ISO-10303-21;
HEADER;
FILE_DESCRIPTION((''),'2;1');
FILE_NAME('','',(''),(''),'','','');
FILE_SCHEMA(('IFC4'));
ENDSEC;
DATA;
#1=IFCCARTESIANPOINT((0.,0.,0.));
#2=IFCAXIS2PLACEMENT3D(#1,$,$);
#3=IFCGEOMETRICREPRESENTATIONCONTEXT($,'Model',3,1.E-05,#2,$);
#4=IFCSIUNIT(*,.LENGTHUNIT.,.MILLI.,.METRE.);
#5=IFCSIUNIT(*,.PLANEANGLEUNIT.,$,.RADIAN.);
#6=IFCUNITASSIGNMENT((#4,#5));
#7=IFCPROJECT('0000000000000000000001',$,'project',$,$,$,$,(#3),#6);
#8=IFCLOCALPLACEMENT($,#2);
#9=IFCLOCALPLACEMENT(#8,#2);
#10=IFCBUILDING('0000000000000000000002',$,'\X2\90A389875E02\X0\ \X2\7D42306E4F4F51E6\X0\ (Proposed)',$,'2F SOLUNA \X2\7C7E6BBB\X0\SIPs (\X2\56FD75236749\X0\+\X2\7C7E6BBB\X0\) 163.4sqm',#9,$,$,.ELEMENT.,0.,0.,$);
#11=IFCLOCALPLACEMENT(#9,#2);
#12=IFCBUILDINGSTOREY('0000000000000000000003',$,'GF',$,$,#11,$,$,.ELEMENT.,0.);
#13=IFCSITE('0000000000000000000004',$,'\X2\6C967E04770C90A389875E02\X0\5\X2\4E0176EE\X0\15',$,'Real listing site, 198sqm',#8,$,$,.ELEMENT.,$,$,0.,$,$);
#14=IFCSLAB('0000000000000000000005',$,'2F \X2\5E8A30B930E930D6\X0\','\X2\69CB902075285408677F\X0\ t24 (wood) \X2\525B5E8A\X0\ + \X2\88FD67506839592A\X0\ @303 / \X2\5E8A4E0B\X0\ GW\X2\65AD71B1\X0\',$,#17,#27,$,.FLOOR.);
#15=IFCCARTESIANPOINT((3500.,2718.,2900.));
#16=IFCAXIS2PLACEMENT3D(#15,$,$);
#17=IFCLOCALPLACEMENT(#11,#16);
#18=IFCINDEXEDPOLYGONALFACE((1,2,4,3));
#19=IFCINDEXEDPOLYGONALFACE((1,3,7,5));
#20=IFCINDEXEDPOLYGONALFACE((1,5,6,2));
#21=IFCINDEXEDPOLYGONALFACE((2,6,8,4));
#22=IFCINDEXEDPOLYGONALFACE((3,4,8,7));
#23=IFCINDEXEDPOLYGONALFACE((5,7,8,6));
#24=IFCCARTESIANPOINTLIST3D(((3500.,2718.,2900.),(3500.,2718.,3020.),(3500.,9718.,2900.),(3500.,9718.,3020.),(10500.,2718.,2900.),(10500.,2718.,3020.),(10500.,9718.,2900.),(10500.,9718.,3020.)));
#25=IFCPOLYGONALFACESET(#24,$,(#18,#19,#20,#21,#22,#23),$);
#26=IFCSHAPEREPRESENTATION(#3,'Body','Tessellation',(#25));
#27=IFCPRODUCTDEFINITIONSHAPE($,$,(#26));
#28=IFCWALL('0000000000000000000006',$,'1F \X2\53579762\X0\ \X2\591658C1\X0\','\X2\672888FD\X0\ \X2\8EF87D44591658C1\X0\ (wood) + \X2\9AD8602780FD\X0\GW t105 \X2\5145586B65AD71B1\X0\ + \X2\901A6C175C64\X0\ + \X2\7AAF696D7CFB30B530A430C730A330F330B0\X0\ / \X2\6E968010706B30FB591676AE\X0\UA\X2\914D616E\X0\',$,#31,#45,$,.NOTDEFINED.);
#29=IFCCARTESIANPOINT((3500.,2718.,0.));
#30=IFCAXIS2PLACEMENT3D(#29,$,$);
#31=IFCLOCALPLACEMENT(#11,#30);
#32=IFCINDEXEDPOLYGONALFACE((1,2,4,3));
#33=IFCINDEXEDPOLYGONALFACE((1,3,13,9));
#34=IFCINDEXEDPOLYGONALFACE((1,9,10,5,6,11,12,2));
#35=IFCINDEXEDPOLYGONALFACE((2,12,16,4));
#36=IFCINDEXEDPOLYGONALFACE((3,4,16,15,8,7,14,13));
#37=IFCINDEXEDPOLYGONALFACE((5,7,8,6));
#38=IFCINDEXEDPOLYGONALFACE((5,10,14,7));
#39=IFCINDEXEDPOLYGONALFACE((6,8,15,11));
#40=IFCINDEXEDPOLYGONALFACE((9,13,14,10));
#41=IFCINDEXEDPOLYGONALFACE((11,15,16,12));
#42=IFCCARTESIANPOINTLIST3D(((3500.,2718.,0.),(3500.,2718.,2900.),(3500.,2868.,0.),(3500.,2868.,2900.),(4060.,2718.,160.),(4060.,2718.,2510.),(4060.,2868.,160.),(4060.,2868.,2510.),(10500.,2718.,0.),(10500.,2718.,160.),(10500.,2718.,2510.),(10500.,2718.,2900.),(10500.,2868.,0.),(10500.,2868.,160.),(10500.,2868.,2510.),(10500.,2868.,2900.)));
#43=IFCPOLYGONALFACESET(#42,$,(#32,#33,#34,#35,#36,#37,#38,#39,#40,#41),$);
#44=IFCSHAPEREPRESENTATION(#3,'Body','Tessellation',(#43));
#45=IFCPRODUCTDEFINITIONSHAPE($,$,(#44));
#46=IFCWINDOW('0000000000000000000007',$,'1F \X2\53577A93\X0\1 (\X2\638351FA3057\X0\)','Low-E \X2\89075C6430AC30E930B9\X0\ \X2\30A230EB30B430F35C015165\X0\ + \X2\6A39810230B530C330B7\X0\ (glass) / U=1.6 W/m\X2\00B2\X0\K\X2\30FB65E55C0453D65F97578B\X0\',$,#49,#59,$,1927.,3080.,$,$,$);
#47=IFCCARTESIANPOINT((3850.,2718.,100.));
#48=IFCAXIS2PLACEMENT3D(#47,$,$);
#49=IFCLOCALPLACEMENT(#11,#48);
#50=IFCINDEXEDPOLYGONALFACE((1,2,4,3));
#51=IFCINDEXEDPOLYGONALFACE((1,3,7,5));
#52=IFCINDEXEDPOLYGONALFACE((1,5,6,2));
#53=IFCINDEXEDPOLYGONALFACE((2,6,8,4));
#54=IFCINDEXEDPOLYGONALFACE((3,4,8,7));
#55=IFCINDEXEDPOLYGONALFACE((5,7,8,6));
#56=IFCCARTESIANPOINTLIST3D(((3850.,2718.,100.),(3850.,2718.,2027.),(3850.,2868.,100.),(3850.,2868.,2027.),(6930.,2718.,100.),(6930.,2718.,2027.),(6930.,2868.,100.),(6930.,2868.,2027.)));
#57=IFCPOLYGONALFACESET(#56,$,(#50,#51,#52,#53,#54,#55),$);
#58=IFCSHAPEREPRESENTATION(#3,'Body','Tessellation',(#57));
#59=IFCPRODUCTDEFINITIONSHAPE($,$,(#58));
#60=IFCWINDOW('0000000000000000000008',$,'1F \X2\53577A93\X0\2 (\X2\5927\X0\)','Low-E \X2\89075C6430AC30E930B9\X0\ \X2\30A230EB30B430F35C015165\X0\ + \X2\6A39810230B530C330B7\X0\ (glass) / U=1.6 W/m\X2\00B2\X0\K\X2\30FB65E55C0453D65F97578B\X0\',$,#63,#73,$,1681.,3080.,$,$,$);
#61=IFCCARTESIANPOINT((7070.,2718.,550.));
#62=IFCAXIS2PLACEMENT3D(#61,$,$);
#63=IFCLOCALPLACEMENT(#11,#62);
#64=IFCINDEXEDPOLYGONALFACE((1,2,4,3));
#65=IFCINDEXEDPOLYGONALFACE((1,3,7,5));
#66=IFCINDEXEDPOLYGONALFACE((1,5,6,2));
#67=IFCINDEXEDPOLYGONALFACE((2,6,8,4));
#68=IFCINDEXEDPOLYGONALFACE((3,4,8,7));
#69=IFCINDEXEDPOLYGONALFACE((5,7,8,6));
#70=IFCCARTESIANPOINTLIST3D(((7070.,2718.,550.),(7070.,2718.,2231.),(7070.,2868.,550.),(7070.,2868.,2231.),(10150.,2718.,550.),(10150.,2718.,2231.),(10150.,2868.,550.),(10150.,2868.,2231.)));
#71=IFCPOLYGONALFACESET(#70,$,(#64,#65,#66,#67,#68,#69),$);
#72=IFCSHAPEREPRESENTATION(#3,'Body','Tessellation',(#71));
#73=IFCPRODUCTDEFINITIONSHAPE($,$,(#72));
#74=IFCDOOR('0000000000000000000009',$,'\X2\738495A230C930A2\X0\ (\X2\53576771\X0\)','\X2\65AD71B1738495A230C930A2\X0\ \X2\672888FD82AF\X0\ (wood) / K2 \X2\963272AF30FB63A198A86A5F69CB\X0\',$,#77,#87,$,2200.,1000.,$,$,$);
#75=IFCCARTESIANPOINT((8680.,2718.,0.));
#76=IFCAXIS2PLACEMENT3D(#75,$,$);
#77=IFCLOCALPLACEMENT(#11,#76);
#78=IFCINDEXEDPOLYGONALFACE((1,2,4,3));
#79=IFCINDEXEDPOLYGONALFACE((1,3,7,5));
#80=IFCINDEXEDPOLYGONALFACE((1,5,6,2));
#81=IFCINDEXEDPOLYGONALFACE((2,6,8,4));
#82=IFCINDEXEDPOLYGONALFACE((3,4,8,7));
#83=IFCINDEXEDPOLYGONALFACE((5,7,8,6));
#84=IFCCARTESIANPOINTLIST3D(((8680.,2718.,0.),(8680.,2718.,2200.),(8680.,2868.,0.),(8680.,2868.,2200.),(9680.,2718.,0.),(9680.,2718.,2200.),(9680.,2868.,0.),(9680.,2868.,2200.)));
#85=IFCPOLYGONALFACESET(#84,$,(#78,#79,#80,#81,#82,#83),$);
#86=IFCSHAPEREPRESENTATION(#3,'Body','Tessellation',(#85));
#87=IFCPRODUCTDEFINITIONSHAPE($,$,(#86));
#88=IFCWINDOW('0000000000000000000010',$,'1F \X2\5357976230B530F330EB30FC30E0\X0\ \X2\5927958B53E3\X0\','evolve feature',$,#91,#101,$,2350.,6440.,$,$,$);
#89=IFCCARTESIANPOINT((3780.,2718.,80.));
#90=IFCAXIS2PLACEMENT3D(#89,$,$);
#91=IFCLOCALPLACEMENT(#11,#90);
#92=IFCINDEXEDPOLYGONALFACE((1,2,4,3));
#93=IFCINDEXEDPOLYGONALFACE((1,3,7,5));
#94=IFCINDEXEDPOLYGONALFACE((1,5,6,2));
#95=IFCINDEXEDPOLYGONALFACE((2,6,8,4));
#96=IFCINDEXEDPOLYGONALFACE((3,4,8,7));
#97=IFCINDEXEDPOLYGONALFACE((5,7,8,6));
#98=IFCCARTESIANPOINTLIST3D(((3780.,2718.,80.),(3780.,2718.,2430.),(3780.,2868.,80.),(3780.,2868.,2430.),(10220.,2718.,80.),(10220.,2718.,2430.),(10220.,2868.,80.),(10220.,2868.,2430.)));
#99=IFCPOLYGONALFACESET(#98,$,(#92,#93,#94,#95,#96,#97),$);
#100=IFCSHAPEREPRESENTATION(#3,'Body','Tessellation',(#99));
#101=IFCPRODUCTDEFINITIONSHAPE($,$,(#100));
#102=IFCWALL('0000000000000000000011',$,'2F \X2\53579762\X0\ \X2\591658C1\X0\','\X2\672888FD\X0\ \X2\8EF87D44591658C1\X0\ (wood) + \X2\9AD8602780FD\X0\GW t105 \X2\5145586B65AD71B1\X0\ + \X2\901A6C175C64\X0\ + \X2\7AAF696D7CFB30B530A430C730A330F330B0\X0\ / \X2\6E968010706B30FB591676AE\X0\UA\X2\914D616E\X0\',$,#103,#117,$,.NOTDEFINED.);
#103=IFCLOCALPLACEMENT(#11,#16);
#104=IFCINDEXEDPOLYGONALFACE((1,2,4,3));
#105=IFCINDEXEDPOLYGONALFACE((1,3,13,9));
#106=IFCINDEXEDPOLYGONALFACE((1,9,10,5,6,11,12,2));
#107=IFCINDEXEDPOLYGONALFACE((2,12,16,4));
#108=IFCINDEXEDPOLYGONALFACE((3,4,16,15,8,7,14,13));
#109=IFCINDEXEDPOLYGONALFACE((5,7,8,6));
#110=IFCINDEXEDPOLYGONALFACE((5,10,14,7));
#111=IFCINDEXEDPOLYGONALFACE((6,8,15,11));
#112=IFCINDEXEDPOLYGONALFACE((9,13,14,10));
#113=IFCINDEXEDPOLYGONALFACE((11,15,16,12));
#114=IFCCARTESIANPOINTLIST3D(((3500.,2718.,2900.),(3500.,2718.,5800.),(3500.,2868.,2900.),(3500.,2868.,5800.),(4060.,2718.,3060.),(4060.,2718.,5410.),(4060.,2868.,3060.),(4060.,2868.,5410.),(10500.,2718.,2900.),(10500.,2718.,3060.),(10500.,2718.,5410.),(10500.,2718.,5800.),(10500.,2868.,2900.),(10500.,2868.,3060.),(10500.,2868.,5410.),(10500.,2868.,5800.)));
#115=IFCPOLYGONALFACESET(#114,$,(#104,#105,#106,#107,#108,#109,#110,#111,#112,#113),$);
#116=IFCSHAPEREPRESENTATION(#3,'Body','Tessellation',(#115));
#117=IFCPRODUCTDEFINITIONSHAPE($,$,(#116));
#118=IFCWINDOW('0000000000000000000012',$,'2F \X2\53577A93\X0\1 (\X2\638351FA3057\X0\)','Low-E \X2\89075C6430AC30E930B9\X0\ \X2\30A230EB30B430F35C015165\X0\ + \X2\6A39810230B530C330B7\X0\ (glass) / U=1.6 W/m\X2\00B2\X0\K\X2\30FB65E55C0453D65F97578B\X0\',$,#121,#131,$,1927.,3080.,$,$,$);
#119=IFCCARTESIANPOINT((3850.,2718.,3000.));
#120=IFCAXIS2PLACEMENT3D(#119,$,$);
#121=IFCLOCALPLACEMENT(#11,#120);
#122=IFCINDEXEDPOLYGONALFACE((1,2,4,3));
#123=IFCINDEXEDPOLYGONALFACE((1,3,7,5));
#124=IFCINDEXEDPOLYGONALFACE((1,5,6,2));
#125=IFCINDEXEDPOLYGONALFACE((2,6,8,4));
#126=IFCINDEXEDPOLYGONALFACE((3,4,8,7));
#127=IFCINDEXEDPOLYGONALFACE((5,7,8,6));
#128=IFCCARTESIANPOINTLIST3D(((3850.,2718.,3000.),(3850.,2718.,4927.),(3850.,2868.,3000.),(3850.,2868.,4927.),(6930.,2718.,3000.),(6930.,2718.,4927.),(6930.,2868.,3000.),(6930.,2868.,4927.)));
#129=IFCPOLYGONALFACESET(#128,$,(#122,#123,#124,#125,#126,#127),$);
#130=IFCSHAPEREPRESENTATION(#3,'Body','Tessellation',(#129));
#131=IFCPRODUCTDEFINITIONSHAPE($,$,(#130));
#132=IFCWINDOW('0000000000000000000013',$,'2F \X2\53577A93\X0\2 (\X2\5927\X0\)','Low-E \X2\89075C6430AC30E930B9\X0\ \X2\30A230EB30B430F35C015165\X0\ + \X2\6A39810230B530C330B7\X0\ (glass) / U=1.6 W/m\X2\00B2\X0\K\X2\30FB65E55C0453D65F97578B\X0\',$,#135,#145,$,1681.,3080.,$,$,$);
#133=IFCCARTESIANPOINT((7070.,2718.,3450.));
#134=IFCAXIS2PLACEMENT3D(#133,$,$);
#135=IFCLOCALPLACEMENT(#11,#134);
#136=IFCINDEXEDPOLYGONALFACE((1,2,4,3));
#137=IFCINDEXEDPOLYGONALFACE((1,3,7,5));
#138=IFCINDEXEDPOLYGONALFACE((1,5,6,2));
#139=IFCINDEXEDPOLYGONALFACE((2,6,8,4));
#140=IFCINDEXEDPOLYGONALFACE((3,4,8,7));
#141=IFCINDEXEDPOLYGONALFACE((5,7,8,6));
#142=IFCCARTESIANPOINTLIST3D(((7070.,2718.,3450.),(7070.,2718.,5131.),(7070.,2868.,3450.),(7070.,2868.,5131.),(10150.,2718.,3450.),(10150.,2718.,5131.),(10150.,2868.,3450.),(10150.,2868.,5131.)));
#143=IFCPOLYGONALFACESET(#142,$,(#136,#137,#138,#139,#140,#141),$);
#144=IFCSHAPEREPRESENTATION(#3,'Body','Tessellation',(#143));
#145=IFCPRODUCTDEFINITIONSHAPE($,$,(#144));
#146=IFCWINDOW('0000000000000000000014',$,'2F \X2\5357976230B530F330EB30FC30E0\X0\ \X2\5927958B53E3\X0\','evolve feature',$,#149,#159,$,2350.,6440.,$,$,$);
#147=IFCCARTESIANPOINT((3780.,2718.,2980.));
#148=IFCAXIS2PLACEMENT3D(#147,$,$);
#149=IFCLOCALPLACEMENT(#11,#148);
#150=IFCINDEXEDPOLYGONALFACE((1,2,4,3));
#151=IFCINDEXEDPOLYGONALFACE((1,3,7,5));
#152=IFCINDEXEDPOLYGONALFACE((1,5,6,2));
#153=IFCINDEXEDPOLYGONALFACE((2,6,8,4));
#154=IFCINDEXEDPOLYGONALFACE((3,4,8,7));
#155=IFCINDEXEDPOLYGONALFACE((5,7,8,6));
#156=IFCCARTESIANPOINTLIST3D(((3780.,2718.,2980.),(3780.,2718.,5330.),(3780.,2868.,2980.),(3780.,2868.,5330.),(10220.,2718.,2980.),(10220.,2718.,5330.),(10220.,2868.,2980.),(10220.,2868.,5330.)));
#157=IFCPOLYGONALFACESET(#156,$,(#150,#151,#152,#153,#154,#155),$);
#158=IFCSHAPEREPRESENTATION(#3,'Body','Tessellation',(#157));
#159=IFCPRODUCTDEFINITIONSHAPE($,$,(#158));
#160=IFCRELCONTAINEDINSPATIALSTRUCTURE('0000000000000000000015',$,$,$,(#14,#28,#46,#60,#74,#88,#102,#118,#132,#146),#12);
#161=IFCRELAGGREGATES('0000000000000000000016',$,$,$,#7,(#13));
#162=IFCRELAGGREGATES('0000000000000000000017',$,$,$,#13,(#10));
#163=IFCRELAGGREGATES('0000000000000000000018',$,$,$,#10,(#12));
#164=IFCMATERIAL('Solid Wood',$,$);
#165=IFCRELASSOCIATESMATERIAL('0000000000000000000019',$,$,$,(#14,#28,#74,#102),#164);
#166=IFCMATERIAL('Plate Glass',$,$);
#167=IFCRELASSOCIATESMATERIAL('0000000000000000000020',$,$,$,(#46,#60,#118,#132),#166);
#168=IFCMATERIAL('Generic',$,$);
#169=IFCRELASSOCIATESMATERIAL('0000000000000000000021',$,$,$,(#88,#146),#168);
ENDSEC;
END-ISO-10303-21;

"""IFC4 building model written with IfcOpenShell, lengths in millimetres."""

from ifc_helpers import new_model, si_unit, frame, frame_2d, origin, place, context, project, spatial, rectangle, extrude, material, element, fill, save


model = new_model("IFC4")

# Units and contexts
model_context = context("Model", 3, precision=1e-05, world=origin())
ifc_project = project(units=[si_unit("LENGTHUNIT", "METRE", prefix="MILLI"), si_unit("PLANEANGLEUNIT", "RADIAN")], contexts=[model_context])

# Site, building, storey
site_placement = place(None, origin())
site = spatial("IfcSite", under=ifc_project, at=site_placement, Name="沖縄県那覇市5丁目15", ObjectType="Real listing site, 198sqm", CompositionType="ELEMENT", RefElevation=0.0)
building_placement = place(site_placement, origin())
building = spatial("IfcBuilding", under=site, at=building_placement, Name="那覇市 終の住処 (Proposed)", ObjectType="2F SOLUNA 籾殻SIPs (国産杉+籾殻) 163.4sqm", CompositionType="ELEMENT", ElevationOfRefHeight=0.0, ElevationOfTerrain=0.0)
storey_placement = place(building_placement, origin())
storey = spatial("IfcBuildingStorey", under=building, at=storey_placement, Name="GF", CompositionType="ELEMENT", Elevation=0.0)

# Slab
ifc_material_1 = material(Name="Solid Wood")
slab_1_placement = place(storey_placement, frame((3500.0, 2718.0, 2900.0)))
element("IfcSlab", 1, at=slab_1_placement, inside=storey, material=ifc_material_1, Name="2F 床スラブ", Description="構造用合板 t24 (wood) 剛床 + 製材根太 @303 / 床下 GW断熱", PredefinedType="FLOOR", context=model_context, shape_type="SweptSolid", body=[
    extrude(rectangle(XDim=7000.0, YDim=7000.0, at=frame_2d((3500.0, 3500.0))), frame((3500.0, 2718.0, 2900.0)), (0.0, 0.0, 1.0), 120.0),
])
ifc_material_2 = material(Name="Generic")

# Wall, openings, windows, door
wall_1_placement = place(storey_placement, frame((3500.0, 2718.0, 0.0)))
wall_1 = element("IfcWall", 2, at=wall_1_placement, inside=storey, material=ifc_material_1, Name="1F 南面 外壁", Description="木製 軸組外壁 (wood) + 高性能GW t105 充填断熱 + 通気層 + 窯業系サイディング / 準耐火・外皮UA配慮", PredefinedType="NOTDEFINED", context=model_context, shape_type="SweptSolid", body=[
    extrude(rectangle(XDim=7000.0, YDim=150.0, at=frame_2d((3500.0, 75.0))), frame((3500.0, 2718.0, 0.0)), (0.0, 0.0, 1.0), 2900.0),
])
opening_1_placement = place(storey_placement, frame((3850.0, 2718.0, 100.0)))
opening_1 = element("IfcOpeningElement", 3, at=opening_1_placement, cuts=wall_1, PredefinedType="NOTDEFINED", context=model_context, shape_type="SweptSolid", body=[
    extrude(rectangle(XDim=3080.0, YDim=150.0, at=frame_2d((1540.0, 75.0))), frame((3850.0, 2718.0, 100.0)), (0.0, 0.0, 1.0), 1927.0),
])
opening_2_placement = place(storey_placement, frame((7070.0, 2718.0, 550.0)))
opening_2 = element("IfcOpeningElement", 4, at=opening_2_placement, cuts=wall_1, PredefinedType="NOTDEFINED", context=model_context, shape_type="SweptSolid", body=[
    extrude(rectangle(XDim=3080.0, YDim=150.0, at=frame_2d((1540.0, 75.0))), frame((7070.0, 2718.0, 550.0)), (0.0, 0.0, 1.0), 1681.0),
])
opening_3_placement = place(storey_placement, frame((8680.0, 2718.0, 0.0)))
opening_3 = element("IfcOpeningElement", 5, at=opening_3_placement, cuts=wall_1, PredefinedType="NOTDEFINED", context=model_context, shape_type="SweptSolid", body=[
    extrude(rectangle(XDim=1000.0, YDim=150.0, at=frame_2d((500.0, 75.0))), frame((8680.0, 2718.0, 0.0)), (0.0, 0.0, 1.0), 2200.0),
])
opening_4_placement = place(storey_placement, frame((3780.0, 2718.0, 80.0)))
opening_4 = element("IfcOpeningElement", 6, at=opening_4_placement, cuts=wall_1, PredefinedType="NOTDEFINED", context=model_context, shape_type="SweptSolid", body=[
    extrude(rectangle(XDim=6440.0, YDim=150.0, at=frame_2d((3220.0, 75.0))), frame((3780.0, 2718.0, 80.0)), (0.0, 0.0, 1.0), 2350.0),
])
ifc_material_3 = material(Name="Plate Glass")
window_1_placement = place(storey_placement, frame((3850.0, 2718.0, 100.0)))
window_1 = element("IfcWindow", 7, at=window_1_placement, inside=storey, material=ifc_material_3, Name="1F 南窓1 (掃出し)", Description="Low-E 複層ガラス アルゴン封入 + 樹脂サッシ (glass) / U=1.6 W/m²K・日射取得型", OverallHeight=1927.0, OverallWidth=3080.0, context=model_context, shape_type="SweptSolid", body=[
    extrude(rectangle(XDim=3080.0, YDim=150.0, at=frame_2d((1540.0, 75.0))), frame((3850.0, 2718.0, 100.0)), (0.0, 0.0, 1.0), 1927.0),
])
fill(opening_1, window_1)
window_2_placement = place(storey_placement, frame((7070.0, 2718.0, 550.0)))
window_2 = element("IfcWindow", 8, at=window_2_placement, inside=storey, material=ifc_material_3, Name="1F 南窓2 (大)", Description="Low-E 複層ガラス アルゴン封入 + 樹脂サッシ (glass) / U=1.6 W/m²K・日射取得型", OverallHeight=1681.0, OverallWidth=3080.0, context=model_context, shape_type="SweptSolid", body=[
    extrude(rectangle(XDim=3080.0, YDim=150.0, at=frame_2d((1540.0, 75.0))), frame((7070.0, 2718.0, 550.0)), (0.0, 0.0, 1.0), 1681.0),
])
fill(opening_2, window_2)
door_placement = place(storey_placement, frame((8680.0, 2718.0, 0.0)))
door = element("IfcDoor", 9, at=door_placement, inside=storey, material=ifc_material_1, Name="玄関ドア (南東)", Description="断熱玄関ドア 木製芯 (wood) / K2 防犯・採風機構", OverallHeight=2200.0, OverallWidth=1000.0, context=model_context, shape_type="SweptSolid", body=[
    extrude(rectangle(XDim=1000.0, YDim=150.0, at=frame_2d((500.0, 75.0))), frame((8680.0, 2718.0, 0.0)), (0.0, 0.0, 1.0), 2200.0),
])
fill(opening_3, door)
window_3_placement = place(storey_placement, frame((3780.0, 2718.0, 80.0)))
window_3 = element("IfcWindow", 10, at=window_3_placement, inside=storey, material=ifc_material_2, Name="1F 南面サンルーム 大開口", Description="evolve feature", OverallHeight=2350.0, OverallWidth=6440.0, context=model_context, shape_type="SweptSolid", body=[
    extrude(rectangle(XDim=6440.0, YDim=150.0, at=frame_2d((3220.0, 75.0))), frame((3780.0, 2718.0, 80.0)), (0.0, 0.0, 1.0), 2350.0),
])
fill(opening_4, window_3)

# Wall, openings, windows
wall_2_placement = place(storey_placement, frame((3500.0, 2718.0, 2900.0)))
wall_2 = element("IfcWall", 11, at=wall_2_placement, inside=storey, material=ifc_material_1, Name="2F 南面 外壁", Description="木製 軸組外壁 (wood) + 高性能GW t105 充填断熱 + 通気層 + 窯業系サイディング / 準耐火・外皮UA配慮", PredefinedType="NOTDEFINED", context=model_context, shape_type="SweptSolid", body=[
    extrude(rectangle(XDim=7000.0, YDim=150.0, at=frame_2d((3500.0, 75.0))), frame((3500.0, 2718.0, 2900.0)), (0.0, 0.0, 1.0), 2900.0),
])
opening_5_placement = place(storey_placement, frame((3850.0, 2718.0, 3000.0)))
opening_5 = element("IfcOpeningElement", 12, at=opening_5_placement, cuts=wall_2, PredefinedType="NOTDEFINED", context=model_context, shape_type="SweptSolid", body=[
    extrude(rectangle(XDim=3080.0, YDim=150.0, at=frame_2d((1540.0, 75.0))), frame((3850.0, 2718.0, 3000.0)), (0.0, 0.0, 1.0), 1927.0),
])
opening_6_placement = place(storey_placement, frame((7070.0, 2718.0, 3450.0)))
opening_6 = element("IfcOpeningElement", 13, at=opening_6_placement, cuts=wall_2, PredefinedType="NOTDEFINED", context=model_context, shape_type="SweptSolid", body=[
    extrude(rectangle(XDim=3080.0, YDim=150.0, at=frame_2d((1540.0, 75.0))), frame((7070.0, 2718.0, 3450.0)), (0.0, 0.0, 1.0), 1681.0),
])
opening_7_placement = place(storey_placement, frame((3780.0, 2718.0, 2980.0)))
opening_7 = element("IfcOpeningElement", 14, at=opening_7_placement, cuts=wall_2, PredefinedType="NOTDEFINED", context=model_context, shape_type="SweptSolid", body=[
    extrude(rectangle(XDim=6440.0, YDim=150.0, at=frame_2d((3220.0, 75.0))), frame((3780.0, 2718.0, 2980.0)), (0.0, 0.0, 1.0), 2350.0),
])
window_4_placement = place(storey_placement, frame((3850.0, 2718.0, 3000.0)))
window_4 = element("IfcWindow", 15, at=window_4_placement, inside=storey, material=ifc_material_3, Name="2F 南窓1 (掃出し)", Description="Low-E 複層ガラス アルゴン封入 + 樹脂サッシ (glass) / U=1.6 W/m²K・日射取得型", OverallHeight=1927.0, OverallWidth=3080.0, context=model_context, shape_type="SweptSolid", body=[
    extrude(rectangle(XDim=3080.0, YDim=150.0, at=frame_2d((1540.0, 75.0))), frame((3850.0, 2718.0, 3000.0)), (0.0, 0.0, 1.0), 1927.0),
])
fill(opening_5, window_4)
window_5_placement = place(storey_placement, frame((7070.0, 2718.0, 3450.0)))
window_5 = element("IfcWindow", 16, at=window_5_placement, inside=storey, material=ifc_material_3, Name="2F 南窓2 (大)", Description="Low-E 複層ガラス アルゴン封入 + 樹脂サッシ (glass) / U=1.6 W/m²K・日射取得型", OverallHeight=1681.0, OverallWidth=3080.0, context=model_context, shape_type="SweptSolid", body=[
    extrude(rectangle(XDim=3080.0, YDim=150.0, at=frame_2d((1540.0, 75.0))), frame((7070.0, 2718.0, 3450.0)), (0.0, 0.0, 1.0), 1681.0),
])
fill(opening_6, window_5)
window_6_placement = place(storey_placement, frame((3780.0, 2718.0, 2980.0)))
window_6 = element("IfcWindow", 17, at=window_6_placement, inside=storey, material=ifc_material_2, Name="2F 南面サンルーム 大開口", Description="evolve feature", OverallHeight=2350.0, OverallWidth=6440.0, context=model_context, shape_type="SweptSolid", body=[
    extrude(rectangle(XDim=6440.0, YDim=150.0, at=frame_2d((3220.0, 75.0))), frame((3780.0, 2718.0, 2980.0)), (0.0, 0.0, 1.0), 2350.0),
])
fill(opening_7, window_6)

save(model, "model.ifc")
